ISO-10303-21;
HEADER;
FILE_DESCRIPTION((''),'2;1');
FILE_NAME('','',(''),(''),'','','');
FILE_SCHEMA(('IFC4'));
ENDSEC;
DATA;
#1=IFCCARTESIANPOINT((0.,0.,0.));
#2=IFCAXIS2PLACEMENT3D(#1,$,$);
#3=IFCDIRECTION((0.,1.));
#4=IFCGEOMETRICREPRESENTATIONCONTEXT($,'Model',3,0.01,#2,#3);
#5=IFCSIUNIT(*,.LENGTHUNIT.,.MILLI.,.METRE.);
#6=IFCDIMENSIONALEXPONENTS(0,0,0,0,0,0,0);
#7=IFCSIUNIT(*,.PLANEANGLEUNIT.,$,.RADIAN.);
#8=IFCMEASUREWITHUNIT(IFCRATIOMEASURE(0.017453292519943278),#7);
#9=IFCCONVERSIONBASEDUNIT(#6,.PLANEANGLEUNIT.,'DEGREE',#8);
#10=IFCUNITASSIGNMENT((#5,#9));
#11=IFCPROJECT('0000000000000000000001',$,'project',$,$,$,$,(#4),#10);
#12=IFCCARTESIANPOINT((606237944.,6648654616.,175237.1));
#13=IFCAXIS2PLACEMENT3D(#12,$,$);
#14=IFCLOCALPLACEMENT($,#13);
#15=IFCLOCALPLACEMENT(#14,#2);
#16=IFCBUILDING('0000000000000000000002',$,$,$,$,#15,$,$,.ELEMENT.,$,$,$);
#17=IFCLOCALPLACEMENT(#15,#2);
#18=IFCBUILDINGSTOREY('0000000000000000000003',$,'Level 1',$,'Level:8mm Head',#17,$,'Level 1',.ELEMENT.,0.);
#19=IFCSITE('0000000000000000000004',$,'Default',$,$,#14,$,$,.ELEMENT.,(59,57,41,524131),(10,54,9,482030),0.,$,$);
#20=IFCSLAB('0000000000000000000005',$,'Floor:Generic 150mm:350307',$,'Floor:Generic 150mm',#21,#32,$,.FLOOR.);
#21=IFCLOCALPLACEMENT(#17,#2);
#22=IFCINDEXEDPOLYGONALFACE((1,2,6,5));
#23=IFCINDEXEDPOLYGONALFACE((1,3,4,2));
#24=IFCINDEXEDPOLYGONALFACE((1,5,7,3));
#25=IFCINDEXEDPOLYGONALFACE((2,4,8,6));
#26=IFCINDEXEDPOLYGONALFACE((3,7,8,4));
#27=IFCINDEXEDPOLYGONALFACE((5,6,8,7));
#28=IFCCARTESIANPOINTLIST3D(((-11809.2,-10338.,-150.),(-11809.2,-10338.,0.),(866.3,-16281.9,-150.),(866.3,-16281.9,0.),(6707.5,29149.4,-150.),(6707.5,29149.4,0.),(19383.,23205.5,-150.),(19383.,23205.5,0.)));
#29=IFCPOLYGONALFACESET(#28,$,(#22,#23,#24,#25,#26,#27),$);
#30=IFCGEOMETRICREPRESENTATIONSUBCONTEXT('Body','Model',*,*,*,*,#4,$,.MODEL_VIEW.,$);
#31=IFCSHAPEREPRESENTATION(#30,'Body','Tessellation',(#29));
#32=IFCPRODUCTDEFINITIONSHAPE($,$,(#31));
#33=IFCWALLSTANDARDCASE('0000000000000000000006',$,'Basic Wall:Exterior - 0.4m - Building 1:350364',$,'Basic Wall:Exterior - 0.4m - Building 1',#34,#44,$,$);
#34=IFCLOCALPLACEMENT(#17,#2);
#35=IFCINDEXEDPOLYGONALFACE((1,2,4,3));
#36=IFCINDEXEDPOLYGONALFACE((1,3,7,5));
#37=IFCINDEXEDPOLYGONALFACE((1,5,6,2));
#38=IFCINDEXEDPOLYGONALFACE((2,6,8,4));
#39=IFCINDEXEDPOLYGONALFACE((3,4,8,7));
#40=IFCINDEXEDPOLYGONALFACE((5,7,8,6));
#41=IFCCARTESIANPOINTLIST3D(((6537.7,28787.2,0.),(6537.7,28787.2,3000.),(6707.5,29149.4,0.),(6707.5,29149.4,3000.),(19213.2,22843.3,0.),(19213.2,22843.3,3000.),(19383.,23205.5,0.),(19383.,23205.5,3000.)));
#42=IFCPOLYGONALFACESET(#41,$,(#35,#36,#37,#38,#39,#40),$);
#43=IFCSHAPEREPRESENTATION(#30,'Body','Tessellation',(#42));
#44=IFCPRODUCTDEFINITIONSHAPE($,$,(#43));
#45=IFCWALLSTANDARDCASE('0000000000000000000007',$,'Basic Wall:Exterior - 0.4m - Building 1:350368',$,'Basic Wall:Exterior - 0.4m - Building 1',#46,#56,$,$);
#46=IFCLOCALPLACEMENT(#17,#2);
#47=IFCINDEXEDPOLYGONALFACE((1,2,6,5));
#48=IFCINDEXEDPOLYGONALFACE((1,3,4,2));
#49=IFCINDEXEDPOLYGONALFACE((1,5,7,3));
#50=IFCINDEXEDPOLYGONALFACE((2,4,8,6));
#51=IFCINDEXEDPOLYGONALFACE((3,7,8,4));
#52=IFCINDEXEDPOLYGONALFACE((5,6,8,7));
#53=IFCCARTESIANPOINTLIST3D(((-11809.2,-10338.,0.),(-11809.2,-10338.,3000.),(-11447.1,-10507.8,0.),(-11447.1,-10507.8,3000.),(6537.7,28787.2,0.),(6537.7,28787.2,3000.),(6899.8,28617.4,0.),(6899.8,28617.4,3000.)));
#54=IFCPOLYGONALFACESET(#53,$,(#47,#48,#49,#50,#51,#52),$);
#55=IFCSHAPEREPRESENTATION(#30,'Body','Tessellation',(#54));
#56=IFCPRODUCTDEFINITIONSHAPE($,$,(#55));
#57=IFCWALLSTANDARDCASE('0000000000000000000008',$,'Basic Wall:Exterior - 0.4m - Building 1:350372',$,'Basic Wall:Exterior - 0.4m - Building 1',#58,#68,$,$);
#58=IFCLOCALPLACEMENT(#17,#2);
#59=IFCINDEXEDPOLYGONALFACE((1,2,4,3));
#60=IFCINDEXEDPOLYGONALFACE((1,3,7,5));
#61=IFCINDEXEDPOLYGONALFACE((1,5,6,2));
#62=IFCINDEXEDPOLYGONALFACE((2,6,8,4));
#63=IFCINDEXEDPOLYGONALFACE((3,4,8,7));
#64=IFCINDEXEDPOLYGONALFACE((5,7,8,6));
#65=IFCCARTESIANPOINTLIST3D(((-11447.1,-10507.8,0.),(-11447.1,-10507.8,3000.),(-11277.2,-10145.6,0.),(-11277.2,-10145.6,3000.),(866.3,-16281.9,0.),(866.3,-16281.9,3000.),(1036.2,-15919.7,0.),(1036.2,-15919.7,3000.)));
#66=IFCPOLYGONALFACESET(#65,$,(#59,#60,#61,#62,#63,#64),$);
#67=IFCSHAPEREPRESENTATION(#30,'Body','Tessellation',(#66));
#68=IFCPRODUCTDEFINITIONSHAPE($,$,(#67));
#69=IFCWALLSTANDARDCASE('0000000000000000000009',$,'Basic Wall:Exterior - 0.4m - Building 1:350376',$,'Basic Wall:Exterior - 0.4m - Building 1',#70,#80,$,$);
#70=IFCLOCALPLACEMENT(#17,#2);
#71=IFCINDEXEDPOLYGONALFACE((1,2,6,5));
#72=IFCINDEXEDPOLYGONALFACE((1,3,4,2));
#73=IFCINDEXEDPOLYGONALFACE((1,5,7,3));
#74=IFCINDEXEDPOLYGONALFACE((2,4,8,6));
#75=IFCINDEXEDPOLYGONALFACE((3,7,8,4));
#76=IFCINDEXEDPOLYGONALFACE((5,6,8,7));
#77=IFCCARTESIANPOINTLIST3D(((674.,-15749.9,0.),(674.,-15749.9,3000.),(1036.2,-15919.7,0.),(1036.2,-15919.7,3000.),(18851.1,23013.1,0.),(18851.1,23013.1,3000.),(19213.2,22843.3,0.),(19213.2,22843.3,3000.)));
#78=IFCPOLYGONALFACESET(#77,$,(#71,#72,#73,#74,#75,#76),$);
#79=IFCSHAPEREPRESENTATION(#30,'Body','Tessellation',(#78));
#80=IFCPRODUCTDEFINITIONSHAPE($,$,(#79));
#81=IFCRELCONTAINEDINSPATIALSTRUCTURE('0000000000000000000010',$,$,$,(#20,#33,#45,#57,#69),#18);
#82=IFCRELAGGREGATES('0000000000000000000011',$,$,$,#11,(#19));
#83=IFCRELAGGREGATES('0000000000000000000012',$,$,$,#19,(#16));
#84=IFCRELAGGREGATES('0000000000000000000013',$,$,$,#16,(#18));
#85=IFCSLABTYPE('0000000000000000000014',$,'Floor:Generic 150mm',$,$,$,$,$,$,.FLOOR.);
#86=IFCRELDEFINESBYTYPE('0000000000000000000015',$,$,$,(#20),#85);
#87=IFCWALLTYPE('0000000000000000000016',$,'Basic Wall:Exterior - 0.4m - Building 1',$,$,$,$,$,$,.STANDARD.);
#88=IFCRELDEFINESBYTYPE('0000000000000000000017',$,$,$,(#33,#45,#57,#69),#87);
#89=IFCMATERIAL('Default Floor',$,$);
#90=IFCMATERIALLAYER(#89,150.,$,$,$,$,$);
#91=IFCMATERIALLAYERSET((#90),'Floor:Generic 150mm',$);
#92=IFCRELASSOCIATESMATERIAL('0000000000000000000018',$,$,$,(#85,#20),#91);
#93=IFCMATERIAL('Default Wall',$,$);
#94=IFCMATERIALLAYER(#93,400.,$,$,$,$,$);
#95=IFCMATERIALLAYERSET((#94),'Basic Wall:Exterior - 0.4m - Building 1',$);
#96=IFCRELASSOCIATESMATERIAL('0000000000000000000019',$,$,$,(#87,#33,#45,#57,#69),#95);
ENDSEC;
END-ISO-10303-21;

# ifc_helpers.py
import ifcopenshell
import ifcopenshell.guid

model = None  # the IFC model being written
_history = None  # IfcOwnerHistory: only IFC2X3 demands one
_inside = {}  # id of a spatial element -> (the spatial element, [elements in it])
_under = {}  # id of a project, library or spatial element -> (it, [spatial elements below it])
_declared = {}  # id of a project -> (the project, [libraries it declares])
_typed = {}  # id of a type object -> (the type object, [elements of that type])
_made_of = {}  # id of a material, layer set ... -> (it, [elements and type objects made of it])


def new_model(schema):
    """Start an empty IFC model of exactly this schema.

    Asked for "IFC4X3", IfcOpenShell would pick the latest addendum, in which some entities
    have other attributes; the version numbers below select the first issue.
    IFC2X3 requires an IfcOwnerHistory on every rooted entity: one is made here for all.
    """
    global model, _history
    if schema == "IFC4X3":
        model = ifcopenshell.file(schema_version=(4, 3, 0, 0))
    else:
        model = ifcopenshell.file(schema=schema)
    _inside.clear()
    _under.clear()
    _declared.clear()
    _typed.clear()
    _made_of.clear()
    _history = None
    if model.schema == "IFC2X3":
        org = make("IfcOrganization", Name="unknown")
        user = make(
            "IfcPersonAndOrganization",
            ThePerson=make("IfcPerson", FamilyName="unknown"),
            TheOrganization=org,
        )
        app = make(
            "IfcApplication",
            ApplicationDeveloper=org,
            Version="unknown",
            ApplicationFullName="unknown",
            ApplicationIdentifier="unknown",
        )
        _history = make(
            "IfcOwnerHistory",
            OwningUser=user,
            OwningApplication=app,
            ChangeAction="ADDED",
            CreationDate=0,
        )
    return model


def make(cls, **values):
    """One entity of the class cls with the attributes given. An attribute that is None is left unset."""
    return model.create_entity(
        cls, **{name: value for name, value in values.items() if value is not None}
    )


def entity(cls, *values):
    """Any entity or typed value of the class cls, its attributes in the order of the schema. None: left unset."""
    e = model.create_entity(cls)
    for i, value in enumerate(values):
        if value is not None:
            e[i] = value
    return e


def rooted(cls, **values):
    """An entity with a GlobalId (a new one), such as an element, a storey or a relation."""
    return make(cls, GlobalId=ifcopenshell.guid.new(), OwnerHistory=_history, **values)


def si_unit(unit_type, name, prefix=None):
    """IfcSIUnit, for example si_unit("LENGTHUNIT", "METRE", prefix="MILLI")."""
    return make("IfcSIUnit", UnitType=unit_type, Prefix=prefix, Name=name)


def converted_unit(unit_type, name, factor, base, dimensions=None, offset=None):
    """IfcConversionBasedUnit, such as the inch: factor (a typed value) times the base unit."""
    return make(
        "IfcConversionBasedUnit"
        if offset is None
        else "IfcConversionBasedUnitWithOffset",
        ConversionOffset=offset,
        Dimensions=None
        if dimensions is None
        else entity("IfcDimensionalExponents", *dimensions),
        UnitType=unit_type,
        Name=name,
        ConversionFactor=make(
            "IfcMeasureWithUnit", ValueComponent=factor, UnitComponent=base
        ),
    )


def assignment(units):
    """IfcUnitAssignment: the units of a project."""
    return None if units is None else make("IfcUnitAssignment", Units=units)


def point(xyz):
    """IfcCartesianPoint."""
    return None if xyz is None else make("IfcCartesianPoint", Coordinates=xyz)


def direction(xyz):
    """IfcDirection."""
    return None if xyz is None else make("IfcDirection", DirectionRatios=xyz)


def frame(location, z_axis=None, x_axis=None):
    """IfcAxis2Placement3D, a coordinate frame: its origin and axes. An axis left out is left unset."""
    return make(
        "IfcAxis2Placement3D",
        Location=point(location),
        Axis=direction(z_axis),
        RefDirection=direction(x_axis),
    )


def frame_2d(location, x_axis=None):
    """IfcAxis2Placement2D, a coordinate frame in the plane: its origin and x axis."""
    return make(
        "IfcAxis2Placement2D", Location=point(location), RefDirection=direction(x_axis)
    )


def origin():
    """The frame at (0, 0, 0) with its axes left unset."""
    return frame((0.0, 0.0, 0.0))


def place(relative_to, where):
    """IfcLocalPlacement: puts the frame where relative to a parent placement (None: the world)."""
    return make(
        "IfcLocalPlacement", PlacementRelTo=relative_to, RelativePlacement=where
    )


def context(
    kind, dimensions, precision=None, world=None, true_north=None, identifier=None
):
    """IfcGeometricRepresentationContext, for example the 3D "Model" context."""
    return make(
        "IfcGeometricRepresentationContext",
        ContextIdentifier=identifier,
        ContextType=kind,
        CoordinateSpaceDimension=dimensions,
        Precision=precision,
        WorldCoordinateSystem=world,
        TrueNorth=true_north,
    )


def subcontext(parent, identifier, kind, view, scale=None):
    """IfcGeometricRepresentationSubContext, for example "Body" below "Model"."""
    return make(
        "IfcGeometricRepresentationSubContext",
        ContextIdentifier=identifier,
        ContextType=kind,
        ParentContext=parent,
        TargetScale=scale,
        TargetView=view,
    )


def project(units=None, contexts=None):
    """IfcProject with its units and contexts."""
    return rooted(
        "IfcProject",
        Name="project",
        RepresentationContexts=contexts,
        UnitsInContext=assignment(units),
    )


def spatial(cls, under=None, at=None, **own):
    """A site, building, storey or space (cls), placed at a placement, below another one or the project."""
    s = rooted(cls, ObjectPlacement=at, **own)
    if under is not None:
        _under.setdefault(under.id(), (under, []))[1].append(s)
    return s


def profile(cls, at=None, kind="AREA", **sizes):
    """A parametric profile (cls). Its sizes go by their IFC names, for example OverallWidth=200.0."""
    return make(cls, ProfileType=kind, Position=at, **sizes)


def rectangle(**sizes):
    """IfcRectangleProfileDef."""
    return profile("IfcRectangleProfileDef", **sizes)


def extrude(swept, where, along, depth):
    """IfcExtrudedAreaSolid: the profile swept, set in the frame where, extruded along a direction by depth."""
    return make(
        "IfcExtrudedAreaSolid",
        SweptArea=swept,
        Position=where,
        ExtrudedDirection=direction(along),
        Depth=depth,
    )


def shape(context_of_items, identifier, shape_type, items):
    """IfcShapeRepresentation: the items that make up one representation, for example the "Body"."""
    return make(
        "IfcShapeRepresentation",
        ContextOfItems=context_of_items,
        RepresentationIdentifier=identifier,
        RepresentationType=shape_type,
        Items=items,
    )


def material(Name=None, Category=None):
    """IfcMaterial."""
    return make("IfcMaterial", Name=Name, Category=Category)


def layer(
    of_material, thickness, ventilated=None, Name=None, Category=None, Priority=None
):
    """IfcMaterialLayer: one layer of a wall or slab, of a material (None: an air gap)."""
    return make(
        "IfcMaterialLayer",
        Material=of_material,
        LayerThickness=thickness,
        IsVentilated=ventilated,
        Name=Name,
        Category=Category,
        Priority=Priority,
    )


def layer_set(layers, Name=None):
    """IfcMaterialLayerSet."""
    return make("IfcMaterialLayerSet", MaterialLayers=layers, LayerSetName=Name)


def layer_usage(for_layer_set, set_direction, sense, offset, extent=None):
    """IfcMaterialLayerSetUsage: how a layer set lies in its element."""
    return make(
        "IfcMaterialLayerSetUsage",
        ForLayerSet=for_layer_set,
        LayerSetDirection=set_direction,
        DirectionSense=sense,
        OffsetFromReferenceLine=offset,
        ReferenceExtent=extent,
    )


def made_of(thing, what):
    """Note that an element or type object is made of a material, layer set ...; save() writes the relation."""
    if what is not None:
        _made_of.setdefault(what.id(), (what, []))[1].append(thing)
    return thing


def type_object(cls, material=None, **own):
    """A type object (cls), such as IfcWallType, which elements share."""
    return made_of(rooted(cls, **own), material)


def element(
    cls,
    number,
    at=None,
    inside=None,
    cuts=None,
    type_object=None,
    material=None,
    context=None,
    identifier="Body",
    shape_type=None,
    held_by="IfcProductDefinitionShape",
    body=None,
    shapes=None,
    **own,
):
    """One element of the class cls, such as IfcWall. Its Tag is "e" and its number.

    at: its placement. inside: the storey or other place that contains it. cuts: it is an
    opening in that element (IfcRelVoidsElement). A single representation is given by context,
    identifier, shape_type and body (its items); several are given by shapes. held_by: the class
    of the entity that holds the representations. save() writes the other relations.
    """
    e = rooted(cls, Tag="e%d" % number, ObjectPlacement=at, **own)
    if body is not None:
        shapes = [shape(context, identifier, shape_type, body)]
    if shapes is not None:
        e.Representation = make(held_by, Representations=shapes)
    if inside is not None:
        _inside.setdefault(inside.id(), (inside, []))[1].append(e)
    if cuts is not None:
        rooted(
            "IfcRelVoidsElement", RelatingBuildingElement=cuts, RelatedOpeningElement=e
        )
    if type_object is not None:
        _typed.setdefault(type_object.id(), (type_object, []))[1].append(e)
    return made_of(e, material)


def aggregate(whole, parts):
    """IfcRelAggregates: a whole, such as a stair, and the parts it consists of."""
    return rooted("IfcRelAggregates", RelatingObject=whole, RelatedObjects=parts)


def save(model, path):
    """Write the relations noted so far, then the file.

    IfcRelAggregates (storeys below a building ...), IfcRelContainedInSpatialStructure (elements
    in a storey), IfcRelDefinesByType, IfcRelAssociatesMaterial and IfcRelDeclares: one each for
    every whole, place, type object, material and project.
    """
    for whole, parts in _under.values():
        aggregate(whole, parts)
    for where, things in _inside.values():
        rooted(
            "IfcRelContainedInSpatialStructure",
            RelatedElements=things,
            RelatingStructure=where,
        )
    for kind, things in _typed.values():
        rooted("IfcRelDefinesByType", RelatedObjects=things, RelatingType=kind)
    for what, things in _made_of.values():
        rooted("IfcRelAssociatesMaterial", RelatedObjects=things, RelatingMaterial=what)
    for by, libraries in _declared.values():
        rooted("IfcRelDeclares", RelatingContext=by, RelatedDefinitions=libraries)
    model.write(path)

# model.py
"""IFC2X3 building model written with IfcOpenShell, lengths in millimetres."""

from ifc_helpers import new_model, entity, si_unit, converted_unit, direction, frame, frame_2d, origin, place, context, subcontext, project, spatial, rectangle, extrude, material, layer, layer_set, layer_usage, type_object, element, save


model = new_model("IFC2X3")

# Units and contexts
model_context = context("Model", 3, precision=0.01, world=origin(), true_north=direction((0.0, 1.0)))
body_context = subcontext(model_context, "Body", "Model", "MODEL_VIEW")
ifc_project = project(units=[si_unit("LENGTHUNIT", "METRE", prefix="MILLI"), converted_unit("PLANEANGLEUNIT", "DEGREE", entity("IfcRatioMeasure", 0.017453292519943278), si_unit("PLANEANGLEUNIT", "RADIAN"), dimensions=[0, 0, 0, 0, 0, 0, 0])], contexts=[model_context])

# Site, building, storey
site_placement = place(None, frame((606237944.0, 6648654616.0, 175237.1)))
site = spatial("IfcSite", under=ifc_project, at=site_placement, Name="Default", CompositionType="ELEMENT", RefLatitude=(59, 57, 41, 524131), RefLongitude=(10, 54, 9, 482030), RefElevation=0.0)
building_placement = place(site_placement, origin())
building = spatial("IfcBuilding", under=site, at=building_placement, CompositionType="ELEMENT")
storey_placement = place(building_placement, origin())
storey = spatial("IfcBuildingStorey", under=building, at=storey_placement, Name="Level 1", ObjectType="Level:8mm Head", LongName="Level 1", CompositionType="ELEMENT", Elevation=0.0)

# Slab
ifc_material_1 = material(Name="Default Floor")
ifc_layer_1 = layer(ifc_material_1, 150.0)
ifc_layer_set_1 = layer_set([ifc_layer_1], Name="Floor:Generic 150mm")
ifc_layer_usage_1 = layer_usage(ifc_layer_set_1, "AXIS3", "POSITIVE", 0.0)
slab_type = type_object("IfcSlabType", Name="Floor:Generic 150mm", PredefinedType="FLOOR", material=ifc_layer_set_1)
slab_placement = place(building_placement, origin())
element("IfcSlab", 1, at=slab_placement, inside=storey, type_object=slab_type, material=ifc_layer_usage_1, Name="Floor:Generic 150mm:350307", ObjectType="Floor:Generic 150mm", PredefinedType="FLOOR", context=body_context, shape_type="SweptSolid", body=[
    extrude(rectangle(XDim=43613.3, YDim=14000.0, at=frame_2d((0.0, 0.0), x_axis=(1.0, 0.0))), frame((3786.9, 6433.8, 0.0), z_axis=(0.0, 0.0, -1.0), x_axis=(-0.424566, -0.905397, 0.0)), (0.0, 0.0, 1.0), 150.0),
])

# Walls
ifc_material_2 = material(Name="Default Wall")
ifc_layer_2 = layer(ifc_material_2, 400.0)
ifc_layer_set_2 = layer_set([ifc_layer_2], Name="Basic Wall:Exterior - 0.4m - Building 1")
ifc_layer_usage_2 = layer_usage(ifc_layer_set_2, "AXIS2", "POSITIVE", -200.0)
wall_type = type_object("IfcWallType", Name="Basic Wall:Exterior - 0.4m - Building 1", PredefinedType="STANDARD", material=ifc_layer_set_2)
wall_1_placement = place(building_placement, frame((19298.1, 23024.4, 0.0), z_axis=(0.0, 0.0, 1.0), x_axis=(-0.905397, 0.424566, 0.0)))
element("IfcWallStandardCase", 2, at=wall_1_placement, inside=storey, type_object=wall_type, material=ifc_layer_usage_2, Name="Basic Wall:Exterior - 0.4m - Building 1:350364", ObjectType="Basic Wall:Exterior - 0.4m - Building 1", context=body_context, shape_type="SweptSolid", body=[
    extrude(rectangle(XDim=14000.0, YDim=400.0, at=frame_2d((7000.0, 0.0), x_axis=(-1.0, 0.0))), origin(), (0.0, 0.0, 1.0), 3000.0),
])
wall_2_placement = place(building_placement, frame((6718.7, 28702.3, 0.0), z_axis=(0.0, 0.0, 1.0), x_axis=(-0.424566, -0.905397, 0.0)))
element("IfcWallStandardCase", 3, at=wall_2_placement, inside=storey, type_object=wall_type, material=ifc_layer_usage_2, Name="Basic Wall:Exterior - 0.4m - Building 1:350368", ObjectType="Basic Wall:Exterior - 0.4m - Building 1", context=body_context, shape_type="SweptSolid", body=[
    extrude(rectangle(XDim=43213.3, YDim=400.0, at=frame_2d((21606.7, 0.0), x_axis=(-1.0, 0.0))), origin(), (0.0, 0.0, 1.0), 3000.0),
])
wall_3_placement = place(building_placement, frame((-11362.2, -10326.7, 0.0), z_axis=(0.0, 0.0, 1.0), x_axis=(0.905397, -0.424566, 0.0)))
element("IfcWallStandardCase", 4, at=wall_3_placement, inside=storey, type_object=wall_type, material=ifc_layer_usage_2, Name="Basic Wall:Exterior - 0.4m - Building 1:350372", ObjectType="Basic Wall:Exterior - 0.4m - Building 1", context=body_context, shape_type="SweptSolid", body=[
    extrude(rectangle(XDim=13600.0, YDim=400.0, at=frame_2d((6800.0, 0.0), x_axis=(-1.0, 0.0))), origin(), (0.0, 0.0, 1.0), 3000.0),
])
wall_4_placement = place(building_placement, frame((855.1, -15834.8, 0.0), z_axis=(0.0, 0.0, 1.0), x_axis=(0.424566, 0.905397, 0.0)))
element("IfcWallStandardCase", 5, at=wall_4_placement, inside=storey, type_object=wall_type, material=ifc_layer_usage_2, Name="Basic Wall:Exterior - 0.4m - Building 1:350376", ObjectType="Basic Wall:Exterior - 0.4m - Building 1", context=body_context, shape_type="SweptSolid", body=[
    extrude(rectangle(XDim=42813.3, YDim=400.0, at=frame_2d((21406.7, 0.0), x_axis=(-1.0, 0.0))), origin(), (0.0, 0.0, 1.0), 3000.0),
])

save(model, "model.ifc")
